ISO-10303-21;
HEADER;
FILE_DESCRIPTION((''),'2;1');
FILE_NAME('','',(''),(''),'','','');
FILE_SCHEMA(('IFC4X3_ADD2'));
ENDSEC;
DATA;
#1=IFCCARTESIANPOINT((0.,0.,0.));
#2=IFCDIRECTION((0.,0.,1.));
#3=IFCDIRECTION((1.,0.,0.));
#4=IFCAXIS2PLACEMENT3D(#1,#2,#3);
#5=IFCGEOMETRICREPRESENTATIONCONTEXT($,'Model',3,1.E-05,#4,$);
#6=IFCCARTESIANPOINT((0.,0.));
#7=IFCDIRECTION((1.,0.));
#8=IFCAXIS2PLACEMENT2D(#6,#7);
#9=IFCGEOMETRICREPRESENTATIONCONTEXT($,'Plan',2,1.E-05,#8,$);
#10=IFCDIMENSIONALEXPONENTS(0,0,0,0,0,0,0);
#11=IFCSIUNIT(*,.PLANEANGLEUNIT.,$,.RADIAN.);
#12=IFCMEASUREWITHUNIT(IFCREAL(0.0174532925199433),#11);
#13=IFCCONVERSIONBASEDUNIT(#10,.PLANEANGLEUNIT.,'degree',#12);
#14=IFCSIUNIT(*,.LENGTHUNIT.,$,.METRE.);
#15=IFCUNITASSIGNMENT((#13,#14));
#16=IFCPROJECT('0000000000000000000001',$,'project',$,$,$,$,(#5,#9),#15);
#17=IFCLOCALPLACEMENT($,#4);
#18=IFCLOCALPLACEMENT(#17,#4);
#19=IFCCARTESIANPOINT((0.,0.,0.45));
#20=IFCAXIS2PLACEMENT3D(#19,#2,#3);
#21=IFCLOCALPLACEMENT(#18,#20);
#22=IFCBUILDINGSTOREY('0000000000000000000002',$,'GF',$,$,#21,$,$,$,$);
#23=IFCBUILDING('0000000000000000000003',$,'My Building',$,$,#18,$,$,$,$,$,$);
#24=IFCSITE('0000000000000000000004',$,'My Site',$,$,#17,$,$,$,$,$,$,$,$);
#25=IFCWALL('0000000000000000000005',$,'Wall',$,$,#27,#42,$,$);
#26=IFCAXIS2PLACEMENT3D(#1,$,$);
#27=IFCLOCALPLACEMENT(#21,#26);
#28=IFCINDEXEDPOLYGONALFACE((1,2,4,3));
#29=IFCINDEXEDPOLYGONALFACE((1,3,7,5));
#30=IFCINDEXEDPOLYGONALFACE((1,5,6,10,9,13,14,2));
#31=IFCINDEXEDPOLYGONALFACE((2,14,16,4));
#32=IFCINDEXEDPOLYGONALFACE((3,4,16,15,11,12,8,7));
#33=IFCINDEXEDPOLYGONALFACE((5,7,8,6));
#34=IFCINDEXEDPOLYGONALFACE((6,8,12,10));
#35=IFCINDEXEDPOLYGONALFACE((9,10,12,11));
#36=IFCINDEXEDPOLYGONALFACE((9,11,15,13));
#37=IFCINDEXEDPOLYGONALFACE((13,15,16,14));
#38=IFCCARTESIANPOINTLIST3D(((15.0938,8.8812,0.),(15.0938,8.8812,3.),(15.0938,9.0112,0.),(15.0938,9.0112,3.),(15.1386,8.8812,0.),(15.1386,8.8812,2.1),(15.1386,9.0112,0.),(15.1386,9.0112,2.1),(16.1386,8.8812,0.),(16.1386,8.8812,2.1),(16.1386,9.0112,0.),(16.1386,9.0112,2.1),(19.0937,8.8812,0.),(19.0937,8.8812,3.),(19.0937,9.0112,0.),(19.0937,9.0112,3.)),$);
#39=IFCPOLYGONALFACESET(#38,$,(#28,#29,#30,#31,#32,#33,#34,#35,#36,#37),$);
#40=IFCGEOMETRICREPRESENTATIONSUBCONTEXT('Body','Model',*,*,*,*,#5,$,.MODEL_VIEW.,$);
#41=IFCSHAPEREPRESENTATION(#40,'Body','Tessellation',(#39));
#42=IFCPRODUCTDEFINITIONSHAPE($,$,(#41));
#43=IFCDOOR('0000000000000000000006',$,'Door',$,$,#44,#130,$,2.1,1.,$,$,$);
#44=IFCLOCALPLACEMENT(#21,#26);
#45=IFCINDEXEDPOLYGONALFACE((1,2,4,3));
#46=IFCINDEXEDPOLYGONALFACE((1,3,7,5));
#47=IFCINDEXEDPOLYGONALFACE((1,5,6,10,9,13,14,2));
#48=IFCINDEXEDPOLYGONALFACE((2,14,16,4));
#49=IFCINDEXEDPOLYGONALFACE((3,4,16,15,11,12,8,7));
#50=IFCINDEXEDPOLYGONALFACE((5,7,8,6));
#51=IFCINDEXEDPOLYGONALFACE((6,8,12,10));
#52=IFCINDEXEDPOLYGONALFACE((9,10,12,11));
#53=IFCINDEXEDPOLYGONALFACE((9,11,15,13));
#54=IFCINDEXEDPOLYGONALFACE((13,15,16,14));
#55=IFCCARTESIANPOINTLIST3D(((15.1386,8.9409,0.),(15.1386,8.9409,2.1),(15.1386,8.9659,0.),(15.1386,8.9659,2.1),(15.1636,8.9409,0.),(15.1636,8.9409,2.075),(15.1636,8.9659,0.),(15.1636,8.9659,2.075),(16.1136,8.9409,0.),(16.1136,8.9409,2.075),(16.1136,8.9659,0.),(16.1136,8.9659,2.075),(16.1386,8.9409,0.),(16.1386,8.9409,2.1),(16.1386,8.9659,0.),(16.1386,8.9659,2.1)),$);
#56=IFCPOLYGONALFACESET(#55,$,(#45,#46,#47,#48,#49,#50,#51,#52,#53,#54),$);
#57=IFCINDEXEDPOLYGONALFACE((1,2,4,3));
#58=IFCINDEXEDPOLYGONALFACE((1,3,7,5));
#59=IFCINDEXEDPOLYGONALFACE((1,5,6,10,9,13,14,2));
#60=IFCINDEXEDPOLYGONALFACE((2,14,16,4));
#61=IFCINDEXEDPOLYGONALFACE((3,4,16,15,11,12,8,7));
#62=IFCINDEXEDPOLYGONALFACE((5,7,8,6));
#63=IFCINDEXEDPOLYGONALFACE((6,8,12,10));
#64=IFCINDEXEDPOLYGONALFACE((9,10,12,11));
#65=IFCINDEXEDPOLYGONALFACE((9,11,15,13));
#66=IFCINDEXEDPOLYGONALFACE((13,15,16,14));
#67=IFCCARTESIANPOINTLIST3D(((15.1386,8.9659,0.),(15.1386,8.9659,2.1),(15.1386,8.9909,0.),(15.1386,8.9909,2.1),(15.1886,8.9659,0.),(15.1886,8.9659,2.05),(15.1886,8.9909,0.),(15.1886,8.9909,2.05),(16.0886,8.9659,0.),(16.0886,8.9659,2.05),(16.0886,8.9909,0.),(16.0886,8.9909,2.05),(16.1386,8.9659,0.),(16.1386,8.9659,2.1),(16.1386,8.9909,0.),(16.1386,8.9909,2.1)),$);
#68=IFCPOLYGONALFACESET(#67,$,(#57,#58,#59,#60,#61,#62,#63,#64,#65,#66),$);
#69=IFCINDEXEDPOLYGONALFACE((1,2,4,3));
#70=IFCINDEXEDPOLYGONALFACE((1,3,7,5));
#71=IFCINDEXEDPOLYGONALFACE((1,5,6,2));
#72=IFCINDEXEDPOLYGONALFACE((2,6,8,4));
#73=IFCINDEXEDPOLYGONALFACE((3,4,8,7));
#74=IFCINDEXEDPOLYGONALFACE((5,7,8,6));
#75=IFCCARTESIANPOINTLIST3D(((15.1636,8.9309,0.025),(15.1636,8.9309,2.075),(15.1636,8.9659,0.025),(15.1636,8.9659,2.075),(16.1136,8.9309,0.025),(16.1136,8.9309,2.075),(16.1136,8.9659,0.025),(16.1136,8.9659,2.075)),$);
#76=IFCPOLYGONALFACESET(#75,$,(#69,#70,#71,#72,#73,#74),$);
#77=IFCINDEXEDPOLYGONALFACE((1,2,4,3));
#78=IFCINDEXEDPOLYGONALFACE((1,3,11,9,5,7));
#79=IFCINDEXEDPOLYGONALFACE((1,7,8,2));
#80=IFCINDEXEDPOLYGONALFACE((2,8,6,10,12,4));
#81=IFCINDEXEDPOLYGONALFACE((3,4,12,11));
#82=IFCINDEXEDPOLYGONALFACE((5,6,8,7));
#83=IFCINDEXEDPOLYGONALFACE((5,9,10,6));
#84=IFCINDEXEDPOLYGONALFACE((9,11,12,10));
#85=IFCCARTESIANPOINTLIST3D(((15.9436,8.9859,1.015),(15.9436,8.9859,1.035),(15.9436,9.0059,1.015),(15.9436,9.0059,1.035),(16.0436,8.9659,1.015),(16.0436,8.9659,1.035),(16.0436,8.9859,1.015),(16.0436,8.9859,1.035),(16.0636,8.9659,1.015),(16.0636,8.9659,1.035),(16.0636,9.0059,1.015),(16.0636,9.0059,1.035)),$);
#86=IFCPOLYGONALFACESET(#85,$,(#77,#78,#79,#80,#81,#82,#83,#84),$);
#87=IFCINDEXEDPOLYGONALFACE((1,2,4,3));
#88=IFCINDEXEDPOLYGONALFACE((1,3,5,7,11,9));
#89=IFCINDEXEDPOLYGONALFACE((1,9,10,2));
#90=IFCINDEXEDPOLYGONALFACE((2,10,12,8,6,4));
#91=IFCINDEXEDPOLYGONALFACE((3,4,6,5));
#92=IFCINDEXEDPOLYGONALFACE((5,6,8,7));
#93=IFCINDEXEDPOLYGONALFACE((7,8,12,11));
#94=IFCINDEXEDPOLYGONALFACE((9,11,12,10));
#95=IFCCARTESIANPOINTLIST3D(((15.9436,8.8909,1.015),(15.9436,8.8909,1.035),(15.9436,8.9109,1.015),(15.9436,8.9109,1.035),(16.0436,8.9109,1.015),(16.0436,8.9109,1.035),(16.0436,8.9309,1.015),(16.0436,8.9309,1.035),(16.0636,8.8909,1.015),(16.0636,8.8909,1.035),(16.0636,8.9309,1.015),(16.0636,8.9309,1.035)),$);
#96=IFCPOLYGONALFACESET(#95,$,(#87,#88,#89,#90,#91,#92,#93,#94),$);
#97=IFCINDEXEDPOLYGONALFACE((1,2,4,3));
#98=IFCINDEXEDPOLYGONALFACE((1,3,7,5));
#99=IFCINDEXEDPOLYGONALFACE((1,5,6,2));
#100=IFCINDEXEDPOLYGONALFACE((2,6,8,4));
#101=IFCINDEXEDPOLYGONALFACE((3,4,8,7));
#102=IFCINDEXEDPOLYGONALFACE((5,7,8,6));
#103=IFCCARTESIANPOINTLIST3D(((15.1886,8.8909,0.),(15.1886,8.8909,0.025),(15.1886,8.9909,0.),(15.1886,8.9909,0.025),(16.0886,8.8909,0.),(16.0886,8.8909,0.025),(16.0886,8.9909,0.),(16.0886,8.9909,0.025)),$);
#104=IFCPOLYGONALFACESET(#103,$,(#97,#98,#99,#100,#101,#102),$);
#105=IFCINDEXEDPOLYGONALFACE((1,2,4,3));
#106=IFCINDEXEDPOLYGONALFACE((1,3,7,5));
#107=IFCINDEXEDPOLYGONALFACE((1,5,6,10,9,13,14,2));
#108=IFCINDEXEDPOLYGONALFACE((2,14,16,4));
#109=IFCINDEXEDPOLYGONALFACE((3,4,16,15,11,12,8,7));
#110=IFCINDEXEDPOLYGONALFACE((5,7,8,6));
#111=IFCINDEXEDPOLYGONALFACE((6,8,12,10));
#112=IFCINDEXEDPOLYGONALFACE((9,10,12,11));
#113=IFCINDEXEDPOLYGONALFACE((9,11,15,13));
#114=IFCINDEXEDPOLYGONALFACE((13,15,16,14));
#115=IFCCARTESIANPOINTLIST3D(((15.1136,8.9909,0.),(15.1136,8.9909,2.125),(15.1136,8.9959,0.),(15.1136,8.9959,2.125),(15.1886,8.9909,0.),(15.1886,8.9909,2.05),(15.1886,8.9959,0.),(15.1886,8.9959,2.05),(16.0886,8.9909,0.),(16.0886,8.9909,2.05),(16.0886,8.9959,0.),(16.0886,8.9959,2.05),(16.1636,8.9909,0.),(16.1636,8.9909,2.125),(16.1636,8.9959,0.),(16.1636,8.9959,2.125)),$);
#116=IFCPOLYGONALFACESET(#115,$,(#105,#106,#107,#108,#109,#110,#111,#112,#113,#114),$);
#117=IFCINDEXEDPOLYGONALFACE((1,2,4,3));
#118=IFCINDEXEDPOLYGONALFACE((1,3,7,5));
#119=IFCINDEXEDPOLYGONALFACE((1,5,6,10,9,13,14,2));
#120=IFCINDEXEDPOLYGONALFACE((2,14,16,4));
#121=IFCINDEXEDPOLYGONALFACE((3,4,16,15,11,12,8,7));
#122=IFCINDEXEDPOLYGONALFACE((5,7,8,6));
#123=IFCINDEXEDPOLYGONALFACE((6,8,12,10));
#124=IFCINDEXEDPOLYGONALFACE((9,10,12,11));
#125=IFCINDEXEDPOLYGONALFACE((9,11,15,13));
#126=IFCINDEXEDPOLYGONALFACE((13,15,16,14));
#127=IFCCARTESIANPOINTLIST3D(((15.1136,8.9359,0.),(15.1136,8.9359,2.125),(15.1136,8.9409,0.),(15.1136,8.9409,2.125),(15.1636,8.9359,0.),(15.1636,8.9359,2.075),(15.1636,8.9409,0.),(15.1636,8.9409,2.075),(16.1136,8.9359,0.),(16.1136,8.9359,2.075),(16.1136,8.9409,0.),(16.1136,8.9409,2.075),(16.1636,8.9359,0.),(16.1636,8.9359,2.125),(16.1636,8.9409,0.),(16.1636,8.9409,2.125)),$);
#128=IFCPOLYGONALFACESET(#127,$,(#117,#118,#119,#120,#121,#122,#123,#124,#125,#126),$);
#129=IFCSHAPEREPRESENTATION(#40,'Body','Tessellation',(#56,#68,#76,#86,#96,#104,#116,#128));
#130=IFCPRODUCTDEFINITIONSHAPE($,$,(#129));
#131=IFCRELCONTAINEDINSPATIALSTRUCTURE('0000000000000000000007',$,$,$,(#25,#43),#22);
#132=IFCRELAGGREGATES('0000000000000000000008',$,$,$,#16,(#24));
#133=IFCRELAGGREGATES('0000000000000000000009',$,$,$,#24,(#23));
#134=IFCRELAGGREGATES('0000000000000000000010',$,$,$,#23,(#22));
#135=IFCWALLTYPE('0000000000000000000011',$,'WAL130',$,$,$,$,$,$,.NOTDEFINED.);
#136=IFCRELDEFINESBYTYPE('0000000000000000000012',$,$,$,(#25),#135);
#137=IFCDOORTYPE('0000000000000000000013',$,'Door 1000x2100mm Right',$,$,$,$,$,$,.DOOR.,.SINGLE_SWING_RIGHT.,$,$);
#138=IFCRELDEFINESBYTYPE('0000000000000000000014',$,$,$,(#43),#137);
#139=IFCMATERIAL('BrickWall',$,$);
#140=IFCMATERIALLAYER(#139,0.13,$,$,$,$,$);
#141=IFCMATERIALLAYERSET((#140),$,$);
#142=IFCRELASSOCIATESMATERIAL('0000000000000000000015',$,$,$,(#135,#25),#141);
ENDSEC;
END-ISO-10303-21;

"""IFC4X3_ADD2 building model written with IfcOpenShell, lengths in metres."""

from ifc_helpers import new_model, entity, si_unit, converted_unit, frame, origin_with_axes, origin_2d_with_axis, place, context, subcontext, project, spatial, line, indexed_curve, outline, extrude, shape, source, transform, mapped, material, layer, layer_set, layer_usage, type_object, type_shapes, element, fill, save


model = new_model("IFC4X3_ADD2")

# Units and contexts
model_context = context("Model", 3, precision=1e-05, world=origin_with_axes())
plan_context = context("Plan", 2, precision=1e-05, world=origin_2d_with_axis())
body_context_1 = subcontext(model_context, "Body", "Model", "MODEL_VIEW")
body_context_2 = subcontext(plan_context, "Body", "Plan", "PLAN_VIEW")
ifc_project = project(units=[converted_unit("PLANEANGLEUNIT", "degree", entity("IfcReal", 0.0174532925199433), si_unit("PLANEANGLEUNIT", "RADIAN"), dimensions=[0, 0, 0, 0, 0, 0, 0]), si_unit("LENGTHUNIT", "METRE")], contexts=[model_context, plan_context])

# Site, building, storey
site_placement = place(None, origin_with_axes())
site = spatial("IfcSite", under=ifc_project, at=site_placement, Name="My Site")
building_placement = place(site_placement, origin_with_axes())
building = spatial("IfcBuilding", under=site, at=building_placement, Name="My Building")
storey_placement = place(building_placement, frame((0.0, 0.0, 0.45), z_axis=(0.0, 0.0, 1.0), x_axis=(1.0, 0.0, 0.0)))
storey = spatial("IfcBuildingStorey", under=building, at=storey_placement, Name="GF")

# Shared definitions
ifc_material_1 = material(Name="BrickWall")

# Wall, opening, door
ifc_layer_1 = layer(ifc_material_1, 0.13)
ifc_layer_set_1 = layer_set([ifc_layer_1])
ifc_layer_usage_1 = layer_usage(ifc_layer_set_1, "AXIS2", "POSITIVE", 0.0)
wall_type_1 = type_object("IfcWallType", Name="WAL130", PredefinedType="NOTDEFINED", material=ifc_layer_set_1)
wall_1_placement = place(storey_placement, frame((15.0938, 8.8812, 0.0), z_axis=(0.0, 0.0, 1.0), x_axis=(1.0, 0.0, 0.0)))
wall_1 = element("IfcWall", 1, at=wall_1_placement, inside=storey, type_object=wall_type_1, material=ifc_layer_usage_1, Name="Wall", context=body_context_1, shape_type="SweptSolid", body=[
    extrude(outline(indexed_curve([(0.0, 0.0), (0.0, 0.13), (3.9999, 0.13), (3.9999, 0.0), (0.0, 0.0)], self_intersect=False)), origin_with_axes(), (0.0, 0.0, 1.0), 3.0),
])
shared_shape_1 = source(origin_with_axes(), body_context_1, "Body", "SweptSolid", [
    extrude(outline(indexed_curve([(0.0, 0.0), (1.0, 0.0), (1.0, 2.1), (0.0, 2.1)], segments=[line(1, 2, 3, 4, 1)])), frame((0.0, -0.6, 0.0), z_axis=(0.0, -1.0, 0.0), x_axis=(1.0, 0.0, 0.0)), (0.0, 0.0, -1.0), 1.2),
])
opening_1_placement = place(wall_1_placement, frame((1.0447, 0.1097, 0.0), z_axis=(0.0, 0.0, 1.0), x_axis=(-1.0, 0.0, 0.0)))
opening_1 = element("IfcOpeningElement", 2, at=opening_1_placement, cuts=wall_1, PredefinedType="OPENING", context=body_context_1, shape_type="MappedRepresentation", body=[
    mapped(shared_shape_1, transform((0.0, 0.0, 0.0), x_axis=(1.0, 0.0, 0.0), y_axis=(0.0, 1.0, 0.0), z_axis=(0.0, 0.0, 1.0), scale=1.0)),
])
door_type_1 = type_object("IfcDoorType", Name="Door 1000x2100mm Right", OperationType="SINGLE_SWING_RIGHT", PredefinedType="DOOR")
shared_shape_2 = source(origin_with_axes(), body_context_1, "Body", "SweptSolid", [
    extrude(outline(indexed_curve([(0.0, 0.0), (0.0, 2.1), (1.0, 2.1), (1.0, 0.0), (0.975, 0.0), (0.975, 2.075), (0.025, 2.075), (0.025, 0.0)], segments=[line(1, 2, 3, 4, 5, 6, 7, 8, 1)])), frame((0.0, 0.025, 0.0), z_axis=(0.0, -1.0, 0.0), x_axis=(1.0, 0.0, 0.0)), (0.0, 0.0, -1.0), 0.025),
    extrude(outline(indexed_curve([(0.0, 0.0), (0.0, 2.1), (1.0, 2.1), (1.0, 0.0), (0.95, 0.0), (0.95, 2.05), (0.05, 2.05), (0.05, 0.0)], segments=[line(1, 2, 3, 4, 5, 6, 7, 8, 1)])), frame((0.0, 0.0, 0.0), z_axis=(0.0, -1.0, 0.0), x_axis=(1.0, 0.0, 0.0)), (0.0, 0.0, -1.0), 0.025),
    extrude(outline(indexed_curve([(0.0, 0.0), (0.95, 0.0), (0.95, 0.035), (0.0, 0.035)], segments=[line(1, 2, 3, 4, 1)])), frame((0.025, 0.025, 0.025), z_axis=(0.0, 0.0, 1.0), x_axis=(1.0, 0.0, 0.0)), (0.0, 0.0, 1.0), 2.05),
    extrude(outline(indexed_curve([(0.0, 0.0), (0.0, -0.04), (0.12, -0.04), (0.12, -0.02), (0.02, -0.02), (0.02, 0.0)], segments=[line(1, 2, 3, 4, 5, 6, 1)])), frame((0.075, 0.025, 1.015), z_axis=(0.0, 0.0, 1.0), x_axis=(1.0, 0.0, 0.0)), (0.0, 0.0, 1.0), 0.02),
    extrude(outline(indexed_curve([(0.0, 0.0), (0.0, 0.04), (0.12, 0.04), (0.12, 0.02), (0.02, 0.02), (0.02, 0.0)], segments=[line(1, 2, 3, 4, 5, 6, 1)])), frame((0.075, 0.06, 1.015), z_axis=(0.0, 0.0, 1.0), x_axis=(1.0, 0.0, 0.0)), (0.0, 0.0, 1.0), 0.02),
    extrude(outline(indexed_curve([(0.0, 0.0), (0.9, 0.0), (0.9, 0.1), (0.0, 0.1)], segments=[line(1, 2, 3, 4, 1)])), frame((0.05, 0.0, 0.0), z_axis=(0.0, 0.0, 1.0), x_axis=(1.0, 0.0, 0.0)), (0.0, 0.0, 1.0), 0.025),
    extrude(outline(indexed_curve([(0.0, 0.0), (0.0, 2.125), (1.05, 2.125), (1.05, 0.0), (0.975, 0.0), (0.975, 2.05), (0.075, 2.05), (0.075, 0.0)], segments=[line(1, 2, 3, 4, 5, 6, 7, 8, 1)])), frame((-0.025, -0.005, 0.0), z_axis=(0.0, -1.0, 0.0), x_axis=(1.0, 0.0, 0.0)), (0.0, 0.0, -1.0), 0.005),
    extrude(outline(indexed_curve([(0.0, 0.0), (0.0, 2.125), (1.05, 2.125), (1.05, 0.0), (1.0, 0.0), (1.0, 2.075), (0.05, 2.075), (0.05, 0.0)], segments=[line(1, 2, 3, 4, 5, 6, 7, 8, 1)])), frame((-0.025, 0.05, 0.0), z_axis=(0.0, -1.0, 0.0), x_axis=(1.0, 0.0, 0.0)), (0.0, 0.0, -1.0), 0.005),
])
shared_shape_3 = source(origin_with_axes(), body_context_2, "Body", "Curve2D", [
    entity("IfcIndexedPolyCurve", entity("IfcCartesianPointList2D", [[0.0, 0.0], [0.0, 0.05], [0.025, 0.05], [0.025, 0.025], [0.05, 0.025], [0.05, 0.0]]), [entity("IfcLineIndex", [1, 2, 3, 4, 5, 6, 1])]),
    entity("IfcIndexedPolyCurve", entity("IfcCartesianPointList2D", [[1.0, 0.0], [1.0, 0.05], [0.975, 0.05], [0.975, 0.025], [0.95, 0.025], [0.95, 0.0]]), [entity("IfcLineIndex", [1, 2, 3, 4, 5, 6, 1])]),
    entity("IfcTrimmedCurve", entity("IfcEllipse", entity("IfcAxis2Placement2D", entity("IfcCartesianPoint", [0.94, 0.05]), entity("IfcDirection", [1.0, 0.0])), 0.915, 0.95), [entity("IfcCartesianPoint", [0.94, 1.0])], [entity("IfcCartesianPoint", [0.025, 0.05])], True, "CARTESIAN"),
    entity("IfcIndexedPolyCurve", entity("IfcCartesianPointList2D", [[0.975, 0.05], [0.94, 0.05], [0.94, 1.0], [0.975, 1.0]]), [entity("IfcLineIndex", [1, 2, 3, 4, 1])]),
])
type_shapes(door_type_1, [shared_shape_2, shared_shape_3])
door_1_placement = place(opening_1_placement, origin_with_axes())
door_1 = element("IfcDoor", 3, at=door_1_placement, inside=storey, type_object=door_type_1, Name="Door", OverallHeight=2.1, OverallWidth=1.0, shapes=[
    shape(body_context_1, "Body", "MappedRepresentation", [mapped(shared_shape_2, transform((0.0, 0.0, 0.0), x_axis=(1.0, 0.0, 0.0), y_axis=(0.0, 1.0, 0.0), z_axis=(0.0, 0.0, 1.0), scale=1.0))]),
    shape(body_context_2, "Body", "MappedRepresentation", [mapped(shared_shape_3, transform((0.0, 0.0, 0.0), x_axis=(1.0, 0.0, 0.0), y_axis=(0.0, 1.0, 0.0), z_axis=(0.0, 0.0, 1.0), scale=1.0))]),
])
fill(opening_1, door_1)

save(model, "model.ifc")
